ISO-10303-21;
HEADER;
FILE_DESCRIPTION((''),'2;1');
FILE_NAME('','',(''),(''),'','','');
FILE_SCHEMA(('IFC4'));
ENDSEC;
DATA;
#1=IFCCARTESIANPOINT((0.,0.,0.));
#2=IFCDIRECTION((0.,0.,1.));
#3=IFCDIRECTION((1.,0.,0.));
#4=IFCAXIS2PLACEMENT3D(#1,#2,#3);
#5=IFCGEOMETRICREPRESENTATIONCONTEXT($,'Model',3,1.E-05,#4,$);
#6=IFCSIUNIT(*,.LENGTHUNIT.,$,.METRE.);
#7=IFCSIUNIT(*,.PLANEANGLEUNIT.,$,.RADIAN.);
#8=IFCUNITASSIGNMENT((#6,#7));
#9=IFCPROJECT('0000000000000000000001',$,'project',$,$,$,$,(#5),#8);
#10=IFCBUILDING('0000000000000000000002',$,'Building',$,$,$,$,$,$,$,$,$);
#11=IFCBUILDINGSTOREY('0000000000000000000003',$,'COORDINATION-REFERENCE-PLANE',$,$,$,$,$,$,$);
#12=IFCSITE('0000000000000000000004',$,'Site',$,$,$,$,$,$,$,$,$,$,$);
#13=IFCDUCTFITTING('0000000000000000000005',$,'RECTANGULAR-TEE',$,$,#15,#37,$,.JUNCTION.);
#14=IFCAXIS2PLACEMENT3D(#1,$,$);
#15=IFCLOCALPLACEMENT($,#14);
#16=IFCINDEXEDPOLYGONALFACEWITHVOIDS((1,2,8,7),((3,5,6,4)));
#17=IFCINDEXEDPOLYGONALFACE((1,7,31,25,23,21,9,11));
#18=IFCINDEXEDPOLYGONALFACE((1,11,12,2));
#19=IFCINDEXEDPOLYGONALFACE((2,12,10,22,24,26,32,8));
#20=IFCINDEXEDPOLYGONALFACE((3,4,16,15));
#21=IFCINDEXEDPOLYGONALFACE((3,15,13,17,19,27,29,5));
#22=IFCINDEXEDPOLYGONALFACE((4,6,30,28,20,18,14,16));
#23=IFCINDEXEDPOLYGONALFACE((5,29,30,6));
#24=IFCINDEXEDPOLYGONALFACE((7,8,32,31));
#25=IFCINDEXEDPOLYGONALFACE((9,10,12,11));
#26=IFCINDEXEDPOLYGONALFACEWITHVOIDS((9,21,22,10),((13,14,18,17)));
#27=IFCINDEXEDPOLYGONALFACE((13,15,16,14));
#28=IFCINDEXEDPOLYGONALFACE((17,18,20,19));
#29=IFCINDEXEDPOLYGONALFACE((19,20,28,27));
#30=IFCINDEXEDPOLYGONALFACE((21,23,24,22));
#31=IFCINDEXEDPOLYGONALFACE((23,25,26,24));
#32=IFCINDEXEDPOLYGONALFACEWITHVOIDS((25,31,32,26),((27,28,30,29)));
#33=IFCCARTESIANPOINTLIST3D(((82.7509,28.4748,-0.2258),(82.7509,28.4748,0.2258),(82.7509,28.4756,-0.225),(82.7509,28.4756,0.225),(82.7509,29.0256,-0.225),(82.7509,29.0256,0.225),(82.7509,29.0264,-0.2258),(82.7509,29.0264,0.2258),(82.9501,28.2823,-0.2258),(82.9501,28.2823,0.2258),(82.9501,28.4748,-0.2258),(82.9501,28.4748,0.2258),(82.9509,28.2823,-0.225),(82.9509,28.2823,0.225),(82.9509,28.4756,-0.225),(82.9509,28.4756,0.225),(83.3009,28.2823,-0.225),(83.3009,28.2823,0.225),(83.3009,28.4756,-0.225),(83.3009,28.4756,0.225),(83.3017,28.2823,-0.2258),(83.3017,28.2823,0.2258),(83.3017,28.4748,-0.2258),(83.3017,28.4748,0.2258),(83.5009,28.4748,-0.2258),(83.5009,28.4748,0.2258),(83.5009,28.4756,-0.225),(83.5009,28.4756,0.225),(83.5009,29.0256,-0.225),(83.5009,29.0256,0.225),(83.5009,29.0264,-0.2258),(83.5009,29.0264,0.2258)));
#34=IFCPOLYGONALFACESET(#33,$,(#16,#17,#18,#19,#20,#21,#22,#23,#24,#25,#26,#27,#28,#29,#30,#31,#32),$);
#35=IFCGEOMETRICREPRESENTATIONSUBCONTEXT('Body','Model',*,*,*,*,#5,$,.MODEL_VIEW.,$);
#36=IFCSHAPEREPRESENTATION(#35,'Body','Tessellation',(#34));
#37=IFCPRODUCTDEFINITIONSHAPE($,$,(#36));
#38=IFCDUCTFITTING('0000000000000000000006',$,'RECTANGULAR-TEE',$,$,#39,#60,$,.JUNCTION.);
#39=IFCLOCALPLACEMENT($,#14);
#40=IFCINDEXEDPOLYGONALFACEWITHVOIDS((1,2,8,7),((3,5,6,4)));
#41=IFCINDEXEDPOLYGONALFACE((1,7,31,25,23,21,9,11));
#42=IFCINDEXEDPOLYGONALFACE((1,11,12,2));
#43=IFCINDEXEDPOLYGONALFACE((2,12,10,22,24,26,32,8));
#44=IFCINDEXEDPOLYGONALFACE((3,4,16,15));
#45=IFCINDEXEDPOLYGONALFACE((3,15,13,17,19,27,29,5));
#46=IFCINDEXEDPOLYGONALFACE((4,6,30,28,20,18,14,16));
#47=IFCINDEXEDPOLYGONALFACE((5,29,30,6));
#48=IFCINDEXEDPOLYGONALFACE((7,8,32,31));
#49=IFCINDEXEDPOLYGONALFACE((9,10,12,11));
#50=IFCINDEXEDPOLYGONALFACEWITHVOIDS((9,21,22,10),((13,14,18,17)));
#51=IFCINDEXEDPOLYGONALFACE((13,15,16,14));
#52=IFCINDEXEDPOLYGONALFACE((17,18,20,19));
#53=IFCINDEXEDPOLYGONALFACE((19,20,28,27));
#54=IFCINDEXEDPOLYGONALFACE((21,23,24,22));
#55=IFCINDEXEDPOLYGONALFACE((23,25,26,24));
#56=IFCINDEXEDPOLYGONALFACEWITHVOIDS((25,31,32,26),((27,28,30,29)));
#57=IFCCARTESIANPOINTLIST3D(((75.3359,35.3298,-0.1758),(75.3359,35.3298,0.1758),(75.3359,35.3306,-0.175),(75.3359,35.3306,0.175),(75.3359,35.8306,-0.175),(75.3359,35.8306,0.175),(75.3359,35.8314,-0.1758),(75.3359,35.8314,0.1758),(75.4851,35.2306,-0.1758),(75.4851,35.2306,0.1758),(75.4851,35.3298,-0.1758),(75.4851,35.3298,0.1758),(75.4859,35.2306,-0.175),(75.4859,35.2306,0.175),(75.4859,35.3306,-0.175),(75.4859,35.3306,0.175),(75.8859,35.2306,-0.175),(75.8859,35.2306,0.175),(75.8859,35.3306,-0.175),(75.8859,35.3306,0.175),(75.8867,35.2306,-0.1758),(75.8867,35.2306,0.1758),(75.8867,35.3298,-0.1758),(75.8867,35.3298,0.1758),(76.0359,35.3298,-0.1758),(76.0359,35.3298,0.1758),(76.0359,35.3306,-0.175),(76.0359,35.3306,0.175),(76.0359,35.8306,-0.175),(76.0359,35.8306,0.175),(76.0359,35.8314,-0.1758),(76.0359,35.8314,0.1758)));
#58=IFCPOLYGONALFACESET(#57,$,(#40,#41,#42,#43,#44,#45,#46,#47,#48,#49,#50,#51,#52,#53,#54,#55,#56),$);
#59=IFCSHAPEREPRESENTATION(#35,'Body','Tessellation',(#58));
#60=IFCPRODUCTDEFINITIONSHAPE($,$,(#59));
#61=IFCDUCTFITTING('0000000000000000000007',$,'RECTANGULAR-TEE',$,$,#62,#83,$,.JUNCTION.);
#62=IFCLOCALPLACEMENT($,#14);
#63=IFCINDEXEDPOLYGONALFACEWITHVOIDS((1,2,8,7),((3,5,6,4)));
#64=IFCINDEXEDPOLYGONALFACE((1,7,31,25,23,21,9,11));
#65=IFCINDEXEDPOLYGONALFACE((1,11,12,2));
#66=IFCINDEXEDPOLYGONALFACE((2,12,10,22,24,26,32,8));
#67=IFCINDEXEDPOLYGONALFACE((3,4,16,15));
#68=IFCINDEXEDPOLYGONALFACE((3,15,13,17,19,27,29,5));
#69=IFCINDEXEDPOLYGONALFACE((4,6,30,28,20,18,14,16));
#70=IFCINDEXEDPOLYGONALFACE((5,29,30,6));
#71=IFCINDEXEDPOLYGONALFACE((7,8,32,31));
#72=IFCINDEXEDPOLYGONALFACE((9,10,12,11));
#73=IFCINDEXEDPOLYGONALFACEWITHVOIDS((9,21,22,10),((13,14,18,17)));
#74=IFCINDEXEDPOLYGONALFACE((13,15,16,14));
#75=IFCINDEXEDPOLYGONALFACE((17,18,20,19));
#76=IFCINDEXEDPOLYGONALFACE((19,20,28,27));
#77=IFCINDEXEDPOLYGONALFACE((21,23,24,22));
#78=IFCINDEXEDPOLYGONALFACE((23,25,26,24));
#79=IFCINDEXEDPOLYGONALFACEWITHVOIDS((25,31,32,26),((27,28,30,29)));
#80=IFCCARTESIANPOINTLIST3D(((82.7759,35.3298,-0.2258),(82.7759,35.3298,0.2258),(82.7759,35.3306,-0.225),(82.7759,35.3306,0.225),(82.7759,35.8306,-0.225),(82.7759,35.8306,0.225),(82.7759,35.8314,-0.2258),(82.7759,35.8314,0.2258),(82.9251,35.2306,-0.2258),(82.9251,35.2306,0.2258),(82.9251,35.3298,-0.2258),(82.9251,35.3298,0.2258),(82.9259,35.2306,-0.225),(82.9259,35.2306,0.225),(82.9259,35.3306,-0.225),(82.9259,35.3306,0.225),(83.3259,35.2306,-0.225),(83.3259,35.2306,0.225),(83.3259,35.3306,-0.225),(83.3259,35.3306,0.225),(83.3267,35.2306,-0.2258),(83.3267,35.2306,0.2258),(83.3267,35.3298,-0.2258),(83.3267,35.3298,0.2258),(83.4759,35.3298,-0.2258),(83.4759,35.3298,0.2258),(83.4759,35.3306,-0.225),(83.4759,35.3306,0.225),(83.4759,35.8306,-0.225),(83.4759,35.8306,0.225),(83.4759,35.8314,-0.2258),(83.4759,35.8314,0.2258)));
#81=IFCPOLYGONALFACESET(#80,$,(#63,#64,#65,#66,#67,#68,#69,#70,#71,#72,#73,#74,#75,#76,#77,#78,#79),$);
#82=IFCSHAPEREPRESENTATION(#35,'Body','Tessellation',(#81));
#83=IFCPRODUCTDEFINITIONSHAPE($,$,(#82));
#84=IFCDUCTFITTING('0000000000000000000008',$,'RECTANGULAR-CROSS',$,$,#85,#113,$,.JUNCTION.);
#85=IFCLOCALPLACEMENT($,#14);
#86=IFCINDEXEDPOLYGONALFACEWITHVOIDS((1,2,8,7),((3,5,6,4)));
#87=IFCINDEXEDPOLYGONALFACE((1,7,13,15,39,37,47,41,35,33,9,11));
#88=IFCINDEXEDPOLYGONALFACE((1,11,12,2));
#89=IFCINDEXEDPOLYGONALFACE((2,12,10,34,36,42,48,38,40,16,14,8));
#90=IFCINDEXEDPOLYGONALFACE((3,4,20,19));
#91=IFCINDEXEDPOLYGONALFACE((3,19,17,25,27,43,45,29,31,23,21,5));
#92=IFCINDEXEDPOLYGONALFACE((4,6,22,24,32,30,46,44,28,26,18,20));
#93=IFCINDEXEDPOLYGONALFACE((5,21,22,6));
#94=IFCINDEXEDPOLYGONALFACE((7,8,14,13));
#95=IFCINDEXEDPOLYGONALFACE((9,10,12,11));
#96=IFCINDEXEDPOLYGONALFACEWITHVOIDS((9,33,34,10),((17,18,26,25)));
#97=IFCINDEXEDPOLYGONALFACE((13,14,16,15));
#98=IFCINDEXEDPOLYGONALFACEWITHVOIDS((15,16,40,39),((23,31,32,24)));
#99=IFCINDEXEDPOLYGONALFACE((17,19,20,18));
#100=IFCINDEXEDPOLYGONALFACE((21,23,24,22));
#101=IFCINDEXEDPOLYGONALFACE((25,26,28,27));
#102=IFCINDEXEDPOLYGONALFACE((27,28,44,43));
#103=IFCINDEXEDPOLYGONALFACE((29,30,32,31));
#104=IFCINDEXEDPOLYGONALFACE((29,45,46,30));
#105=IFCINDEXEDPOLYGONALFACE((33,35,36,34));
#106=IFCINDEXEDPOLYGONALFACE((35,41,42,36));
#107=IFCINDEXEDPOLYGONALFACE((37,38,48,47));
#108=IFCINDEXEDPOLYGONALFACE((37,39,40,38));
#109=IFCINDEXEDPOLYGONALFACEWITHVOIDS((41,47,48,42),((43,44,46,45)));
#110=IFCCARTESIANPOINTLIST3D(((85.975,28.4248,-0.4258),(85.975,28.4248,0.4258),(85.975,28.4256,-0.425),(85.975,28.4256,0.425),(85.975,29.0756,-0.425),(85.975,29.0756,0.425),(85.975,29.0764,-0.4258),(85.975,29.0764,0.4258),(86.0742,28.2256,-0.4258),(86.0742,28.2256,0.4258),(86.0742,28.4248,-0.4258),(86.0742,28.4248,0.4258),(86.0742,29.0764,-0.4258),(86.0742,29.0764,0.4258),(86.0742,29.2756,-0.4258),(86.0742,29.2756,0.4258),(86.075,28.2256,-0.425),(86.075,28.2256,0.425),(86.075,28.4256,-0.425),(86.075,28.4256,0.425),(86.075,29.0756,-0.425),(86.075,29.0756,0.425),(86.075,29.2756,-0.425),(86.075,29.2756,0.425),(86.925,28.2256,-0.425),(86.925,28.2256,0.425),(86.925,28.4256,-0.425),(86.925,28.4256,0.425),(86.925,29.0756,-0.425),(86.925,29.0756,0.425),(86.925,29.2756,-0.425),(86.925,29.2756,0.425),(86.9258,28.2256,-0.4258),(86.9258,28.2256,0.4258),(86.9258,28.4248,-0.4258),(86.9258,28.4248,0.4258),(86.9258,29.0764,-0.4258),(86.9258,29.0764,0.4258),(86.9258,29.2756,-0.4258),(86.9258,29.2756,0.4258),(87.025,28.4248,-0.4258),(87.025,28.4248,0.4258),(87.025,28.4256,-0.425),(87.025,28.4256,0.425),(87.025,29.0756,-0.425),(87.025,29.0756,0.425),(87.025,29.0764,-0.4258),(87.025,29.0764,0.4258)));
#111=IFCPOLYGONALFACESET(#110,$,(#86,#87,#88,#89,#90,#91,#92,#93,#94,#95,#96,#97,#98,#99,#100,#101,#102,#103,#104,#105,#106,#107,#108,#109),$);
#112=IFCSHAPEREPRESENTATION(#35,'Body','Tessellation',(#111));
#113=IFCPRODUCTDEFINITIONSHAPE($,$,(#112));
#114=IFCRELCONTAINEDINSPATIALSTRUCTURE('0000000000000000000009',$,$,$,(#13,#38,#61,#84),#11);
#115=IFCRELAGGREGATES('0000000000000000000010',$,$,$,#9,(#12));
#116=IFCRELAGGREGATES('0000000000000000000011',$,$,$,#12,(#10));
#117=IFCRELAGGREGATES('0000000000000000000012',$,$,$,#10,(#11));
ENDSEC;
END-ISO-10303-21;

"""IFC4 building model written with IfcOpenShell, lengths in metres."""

from ifc_helpers import new_model, si_unit, frame, origin_with_axes, place, context, subcontext, project, spatial, rectangle, extrude, boolean, element, save


model = new_model("IFC4")

# Units and contexts
model_context = context("Model", 3, precision=1e-05, world=origin_with_axes())
body_context = subcontext(model_context, "Body", "Model", "MODEL_VIEW")
ifc_project = project(units=[si_unit("LENGTHUNIT", "METRE"), si_unit("PLANEANGLEUNIT", "RADIAN")], contexts=[model_context])

# Site, building, storey
site = spatial("IfcSite", under=ifc_project, Name="Site")
building = spatial("IfcBuilding", under=site, Name="Building")
storey = spatial("IfcBuildingStorey", under=building, Name="COORDINATION-REFERENCE-PLANE")

# Duct fittings
duct_fitting_1_placement = place(None, frame((83.1259, 28.7506, 0.0), z_axis=(-1.0, 0.0, 0.0), x_axis=(0.0, -1.0, 0.0)))
solid_1 = boolean("UNION", extrude(rectangle(XDim=0.55, YDim=0.45), frame((0.0, 0.0, -0.375), z_axis=(0.0, 0.0, 1.0), x_axis=(1.0, 0.0, 0.0)), (0.0, 0.0, 1.0), 0.75), extrude(rectangle(XDim=0.35, YDim=0.45), frame((0.0, 0.0, 0.0), z_axis=(1.0, 0.0, 0.0), x_axis=(0.0, 0.0, -1.0)), (0.0, 0.0, 1.0), 0.4683))
element("IfcDuctFitting", 1, at=duct_fitting_1_placement, inside=storey, Name="RECTANGULAR-TEE", PredefinedType="JUNCTION", context=body_context, shape_type="CSG", body=[
    boolean("DIFFERENCE", boolean("UNION", extrude(rectangle(XDim=0.5516, YDim=0.4516), frame((0.0, 0.0, -0.375), z_axis=(0.0, 0.0, 1.0), x_axis=(1.0, 0.0, 0.0)), (0.0, 0.0, 1.0), 0.75), extrude(rectangle(XDim=0.3516, YDim=0.4516), frame((0.0, 0.0, 0.0), z_axis=(1.0, 0.0, 0.0), x_axis=(0.0, 0.0, -1.0)), (0.0, 0.0, 1.0), 0.4683)), solid_1),
])
duct_fitting_2_placement = place(None, frame((75.6859, 35.5806, 0.0), z_axis=(-1.0, 0.0, 0.0), x_axis=(0.0, -1.0, 0.0)))
solid_2 = boolean("UNION", extrude(rectangle(XDim=0.5, YDim=0.35), frame((0.0, 0.0, -0.35), z_axis=(0.0, 0.0, 1.0), x_axis=(1.0, 0.0, 0.0)), (0.0, 0.0, 1.0), 0.7), extrude(rectangle(XDim=0.4, YDim=0.35), frame((0.0, 0.0, 0.0), z_axis=(1.0, 0.0, 0.0), x_axis=(0.0, 0.0, -1.0)), (0.0, 0.0, 1.0), 0.35))
element("IfcDuctFitting", 2, at=duct_fitting_2_placement, inside=storey, Name="RECTANGULAR-TEE", PredefinedType="JUNCTION", context=body_context, shape_type="CSG", body=[
    boolean("DIFFERENCE", boolean("UNION", extrude(rectangle(XDim=0.5016, YDim=0.3516), frame((0.0, 0.0, -0.35), z_axis=(0.0, 0.0, 1.0), x_axis=(1.0, 0.0, 0.0)), (0.0, 0.0, 1.0), 0.7), extrude(rectangle(XDim=0.4016, YDim=0.3516), frame((0.0, 0.0, 0.0), z_axis=(1.0, 0.0, 0.0), x_axis=(0.0, 0.0, -1.0)), (0.0, 0.0, 1.0), 0.35)), solid_2),
])
duct_fitting_3_placement = place(None, frame((83.1259, 35.5806, 0.0), z_axis=(-1.0, 0.0, 0.0), x_axis=(0.0, -1.0, 0.0)))
solid_3 = boolean("UNION", extrude(rectangle(XDim=0.5, YDim=0.45), frame((0.0, 0.0, -0.35), z_axis=(0.0, 0.0, 1.0), x_axis=(1.0, 0.0, 0.0)), (0.0, 0.0, 1.0), 0.7), extrude(rectangle(XDim=0.4, YDim=0.45), frame((0.0, 0.0, 0.0), z_axis=(1.0, 0.0, 0.0), x_axis=(0.0, 0.0, -1.0)), (0.0, 0.0, 1.0), 0.35))
element("IfcDuctFitting", 3, at=duct_fitting_3_placement, inside=storey, Name="RECTANGULAR-TEE", PredefinedType="JUNCTION", context=body_context, shape_type="CSG", body=[
    boolean("DIFFERENCE", boolean("UNION", extrude(rectangle(XDim=0.5016, YDim=0.4516), frame((0.0, 0.0, -0.35), z_axis=(0.0, 0.0, 1.0), x_axis=(1.0, 0.0, 0.0)), (0.0, 0.0, 1.0), 0.7), extrude(rectangle(XDim=0.4016, YDim=0.4516), frame((0.0, 0.0, 0.0), z_axis=(1.0, 0.0, 0.0), x_axis=(0.0, 0.0, -1.0)), (0.0, 0.0, 1.0), 0.35)), solid_3),
])
duct_fitting_4_placement = place(None, frame((86.5, 28.7506, 0.0), z_axis=(0.0, -1.0, 0.0), x_axis=(1.0, 0.0, 0.0)))
solid_4 = boolean("UNION", extrude(rectangle(XDim=0.85, YDim=0.85), frame((0.0, 0.0, -0.525), z_axis=(0.0, 0.0, 1.0), x_axis=(1.0, 0.0, 0.0)), (0.0, 0.0, 1.0), 1.05), extrude(rectangle(XDim=0.65, YDim=0.85), frame((-0.525, 0.0, 0.0), z_axis=(1.0, 0.0, 0.0), x_axis=(0.0, 0.0, -1.0)), (0.0, 0.0, 1.0), 1.05))
element("IfcDuctFitting", 4, at=duct_fitting_4_placement, inside=storey, Name="RECTANGULAR-CROSS", PredefinedType="JUNCTION", context=body_context, shape_type="CSG", body=[
    boolean("DIFFERENCE", boolean("UNION", extrude(rectangle(XDim=0.8516, YDim=0.8516), frame((0.0, 0.0, -0.525), z_axis=(0.0, 0.0, 1.0), x_axis=(1.0, 0.0, 0.0)), (0.0, 0.0, 1.0), 1.05), extrude(rectangle(XDim=0.6516, YDim=0.8516), frame((-0.525, 0.0, 0.0), z_axis=(1.0, 0.0, 0.0), x_axis=(0.0, 0.0, -1.0)), (0.0, 0.0, 1.0), 1.05)), solid_4),
])

save(model, "model.ifc")
